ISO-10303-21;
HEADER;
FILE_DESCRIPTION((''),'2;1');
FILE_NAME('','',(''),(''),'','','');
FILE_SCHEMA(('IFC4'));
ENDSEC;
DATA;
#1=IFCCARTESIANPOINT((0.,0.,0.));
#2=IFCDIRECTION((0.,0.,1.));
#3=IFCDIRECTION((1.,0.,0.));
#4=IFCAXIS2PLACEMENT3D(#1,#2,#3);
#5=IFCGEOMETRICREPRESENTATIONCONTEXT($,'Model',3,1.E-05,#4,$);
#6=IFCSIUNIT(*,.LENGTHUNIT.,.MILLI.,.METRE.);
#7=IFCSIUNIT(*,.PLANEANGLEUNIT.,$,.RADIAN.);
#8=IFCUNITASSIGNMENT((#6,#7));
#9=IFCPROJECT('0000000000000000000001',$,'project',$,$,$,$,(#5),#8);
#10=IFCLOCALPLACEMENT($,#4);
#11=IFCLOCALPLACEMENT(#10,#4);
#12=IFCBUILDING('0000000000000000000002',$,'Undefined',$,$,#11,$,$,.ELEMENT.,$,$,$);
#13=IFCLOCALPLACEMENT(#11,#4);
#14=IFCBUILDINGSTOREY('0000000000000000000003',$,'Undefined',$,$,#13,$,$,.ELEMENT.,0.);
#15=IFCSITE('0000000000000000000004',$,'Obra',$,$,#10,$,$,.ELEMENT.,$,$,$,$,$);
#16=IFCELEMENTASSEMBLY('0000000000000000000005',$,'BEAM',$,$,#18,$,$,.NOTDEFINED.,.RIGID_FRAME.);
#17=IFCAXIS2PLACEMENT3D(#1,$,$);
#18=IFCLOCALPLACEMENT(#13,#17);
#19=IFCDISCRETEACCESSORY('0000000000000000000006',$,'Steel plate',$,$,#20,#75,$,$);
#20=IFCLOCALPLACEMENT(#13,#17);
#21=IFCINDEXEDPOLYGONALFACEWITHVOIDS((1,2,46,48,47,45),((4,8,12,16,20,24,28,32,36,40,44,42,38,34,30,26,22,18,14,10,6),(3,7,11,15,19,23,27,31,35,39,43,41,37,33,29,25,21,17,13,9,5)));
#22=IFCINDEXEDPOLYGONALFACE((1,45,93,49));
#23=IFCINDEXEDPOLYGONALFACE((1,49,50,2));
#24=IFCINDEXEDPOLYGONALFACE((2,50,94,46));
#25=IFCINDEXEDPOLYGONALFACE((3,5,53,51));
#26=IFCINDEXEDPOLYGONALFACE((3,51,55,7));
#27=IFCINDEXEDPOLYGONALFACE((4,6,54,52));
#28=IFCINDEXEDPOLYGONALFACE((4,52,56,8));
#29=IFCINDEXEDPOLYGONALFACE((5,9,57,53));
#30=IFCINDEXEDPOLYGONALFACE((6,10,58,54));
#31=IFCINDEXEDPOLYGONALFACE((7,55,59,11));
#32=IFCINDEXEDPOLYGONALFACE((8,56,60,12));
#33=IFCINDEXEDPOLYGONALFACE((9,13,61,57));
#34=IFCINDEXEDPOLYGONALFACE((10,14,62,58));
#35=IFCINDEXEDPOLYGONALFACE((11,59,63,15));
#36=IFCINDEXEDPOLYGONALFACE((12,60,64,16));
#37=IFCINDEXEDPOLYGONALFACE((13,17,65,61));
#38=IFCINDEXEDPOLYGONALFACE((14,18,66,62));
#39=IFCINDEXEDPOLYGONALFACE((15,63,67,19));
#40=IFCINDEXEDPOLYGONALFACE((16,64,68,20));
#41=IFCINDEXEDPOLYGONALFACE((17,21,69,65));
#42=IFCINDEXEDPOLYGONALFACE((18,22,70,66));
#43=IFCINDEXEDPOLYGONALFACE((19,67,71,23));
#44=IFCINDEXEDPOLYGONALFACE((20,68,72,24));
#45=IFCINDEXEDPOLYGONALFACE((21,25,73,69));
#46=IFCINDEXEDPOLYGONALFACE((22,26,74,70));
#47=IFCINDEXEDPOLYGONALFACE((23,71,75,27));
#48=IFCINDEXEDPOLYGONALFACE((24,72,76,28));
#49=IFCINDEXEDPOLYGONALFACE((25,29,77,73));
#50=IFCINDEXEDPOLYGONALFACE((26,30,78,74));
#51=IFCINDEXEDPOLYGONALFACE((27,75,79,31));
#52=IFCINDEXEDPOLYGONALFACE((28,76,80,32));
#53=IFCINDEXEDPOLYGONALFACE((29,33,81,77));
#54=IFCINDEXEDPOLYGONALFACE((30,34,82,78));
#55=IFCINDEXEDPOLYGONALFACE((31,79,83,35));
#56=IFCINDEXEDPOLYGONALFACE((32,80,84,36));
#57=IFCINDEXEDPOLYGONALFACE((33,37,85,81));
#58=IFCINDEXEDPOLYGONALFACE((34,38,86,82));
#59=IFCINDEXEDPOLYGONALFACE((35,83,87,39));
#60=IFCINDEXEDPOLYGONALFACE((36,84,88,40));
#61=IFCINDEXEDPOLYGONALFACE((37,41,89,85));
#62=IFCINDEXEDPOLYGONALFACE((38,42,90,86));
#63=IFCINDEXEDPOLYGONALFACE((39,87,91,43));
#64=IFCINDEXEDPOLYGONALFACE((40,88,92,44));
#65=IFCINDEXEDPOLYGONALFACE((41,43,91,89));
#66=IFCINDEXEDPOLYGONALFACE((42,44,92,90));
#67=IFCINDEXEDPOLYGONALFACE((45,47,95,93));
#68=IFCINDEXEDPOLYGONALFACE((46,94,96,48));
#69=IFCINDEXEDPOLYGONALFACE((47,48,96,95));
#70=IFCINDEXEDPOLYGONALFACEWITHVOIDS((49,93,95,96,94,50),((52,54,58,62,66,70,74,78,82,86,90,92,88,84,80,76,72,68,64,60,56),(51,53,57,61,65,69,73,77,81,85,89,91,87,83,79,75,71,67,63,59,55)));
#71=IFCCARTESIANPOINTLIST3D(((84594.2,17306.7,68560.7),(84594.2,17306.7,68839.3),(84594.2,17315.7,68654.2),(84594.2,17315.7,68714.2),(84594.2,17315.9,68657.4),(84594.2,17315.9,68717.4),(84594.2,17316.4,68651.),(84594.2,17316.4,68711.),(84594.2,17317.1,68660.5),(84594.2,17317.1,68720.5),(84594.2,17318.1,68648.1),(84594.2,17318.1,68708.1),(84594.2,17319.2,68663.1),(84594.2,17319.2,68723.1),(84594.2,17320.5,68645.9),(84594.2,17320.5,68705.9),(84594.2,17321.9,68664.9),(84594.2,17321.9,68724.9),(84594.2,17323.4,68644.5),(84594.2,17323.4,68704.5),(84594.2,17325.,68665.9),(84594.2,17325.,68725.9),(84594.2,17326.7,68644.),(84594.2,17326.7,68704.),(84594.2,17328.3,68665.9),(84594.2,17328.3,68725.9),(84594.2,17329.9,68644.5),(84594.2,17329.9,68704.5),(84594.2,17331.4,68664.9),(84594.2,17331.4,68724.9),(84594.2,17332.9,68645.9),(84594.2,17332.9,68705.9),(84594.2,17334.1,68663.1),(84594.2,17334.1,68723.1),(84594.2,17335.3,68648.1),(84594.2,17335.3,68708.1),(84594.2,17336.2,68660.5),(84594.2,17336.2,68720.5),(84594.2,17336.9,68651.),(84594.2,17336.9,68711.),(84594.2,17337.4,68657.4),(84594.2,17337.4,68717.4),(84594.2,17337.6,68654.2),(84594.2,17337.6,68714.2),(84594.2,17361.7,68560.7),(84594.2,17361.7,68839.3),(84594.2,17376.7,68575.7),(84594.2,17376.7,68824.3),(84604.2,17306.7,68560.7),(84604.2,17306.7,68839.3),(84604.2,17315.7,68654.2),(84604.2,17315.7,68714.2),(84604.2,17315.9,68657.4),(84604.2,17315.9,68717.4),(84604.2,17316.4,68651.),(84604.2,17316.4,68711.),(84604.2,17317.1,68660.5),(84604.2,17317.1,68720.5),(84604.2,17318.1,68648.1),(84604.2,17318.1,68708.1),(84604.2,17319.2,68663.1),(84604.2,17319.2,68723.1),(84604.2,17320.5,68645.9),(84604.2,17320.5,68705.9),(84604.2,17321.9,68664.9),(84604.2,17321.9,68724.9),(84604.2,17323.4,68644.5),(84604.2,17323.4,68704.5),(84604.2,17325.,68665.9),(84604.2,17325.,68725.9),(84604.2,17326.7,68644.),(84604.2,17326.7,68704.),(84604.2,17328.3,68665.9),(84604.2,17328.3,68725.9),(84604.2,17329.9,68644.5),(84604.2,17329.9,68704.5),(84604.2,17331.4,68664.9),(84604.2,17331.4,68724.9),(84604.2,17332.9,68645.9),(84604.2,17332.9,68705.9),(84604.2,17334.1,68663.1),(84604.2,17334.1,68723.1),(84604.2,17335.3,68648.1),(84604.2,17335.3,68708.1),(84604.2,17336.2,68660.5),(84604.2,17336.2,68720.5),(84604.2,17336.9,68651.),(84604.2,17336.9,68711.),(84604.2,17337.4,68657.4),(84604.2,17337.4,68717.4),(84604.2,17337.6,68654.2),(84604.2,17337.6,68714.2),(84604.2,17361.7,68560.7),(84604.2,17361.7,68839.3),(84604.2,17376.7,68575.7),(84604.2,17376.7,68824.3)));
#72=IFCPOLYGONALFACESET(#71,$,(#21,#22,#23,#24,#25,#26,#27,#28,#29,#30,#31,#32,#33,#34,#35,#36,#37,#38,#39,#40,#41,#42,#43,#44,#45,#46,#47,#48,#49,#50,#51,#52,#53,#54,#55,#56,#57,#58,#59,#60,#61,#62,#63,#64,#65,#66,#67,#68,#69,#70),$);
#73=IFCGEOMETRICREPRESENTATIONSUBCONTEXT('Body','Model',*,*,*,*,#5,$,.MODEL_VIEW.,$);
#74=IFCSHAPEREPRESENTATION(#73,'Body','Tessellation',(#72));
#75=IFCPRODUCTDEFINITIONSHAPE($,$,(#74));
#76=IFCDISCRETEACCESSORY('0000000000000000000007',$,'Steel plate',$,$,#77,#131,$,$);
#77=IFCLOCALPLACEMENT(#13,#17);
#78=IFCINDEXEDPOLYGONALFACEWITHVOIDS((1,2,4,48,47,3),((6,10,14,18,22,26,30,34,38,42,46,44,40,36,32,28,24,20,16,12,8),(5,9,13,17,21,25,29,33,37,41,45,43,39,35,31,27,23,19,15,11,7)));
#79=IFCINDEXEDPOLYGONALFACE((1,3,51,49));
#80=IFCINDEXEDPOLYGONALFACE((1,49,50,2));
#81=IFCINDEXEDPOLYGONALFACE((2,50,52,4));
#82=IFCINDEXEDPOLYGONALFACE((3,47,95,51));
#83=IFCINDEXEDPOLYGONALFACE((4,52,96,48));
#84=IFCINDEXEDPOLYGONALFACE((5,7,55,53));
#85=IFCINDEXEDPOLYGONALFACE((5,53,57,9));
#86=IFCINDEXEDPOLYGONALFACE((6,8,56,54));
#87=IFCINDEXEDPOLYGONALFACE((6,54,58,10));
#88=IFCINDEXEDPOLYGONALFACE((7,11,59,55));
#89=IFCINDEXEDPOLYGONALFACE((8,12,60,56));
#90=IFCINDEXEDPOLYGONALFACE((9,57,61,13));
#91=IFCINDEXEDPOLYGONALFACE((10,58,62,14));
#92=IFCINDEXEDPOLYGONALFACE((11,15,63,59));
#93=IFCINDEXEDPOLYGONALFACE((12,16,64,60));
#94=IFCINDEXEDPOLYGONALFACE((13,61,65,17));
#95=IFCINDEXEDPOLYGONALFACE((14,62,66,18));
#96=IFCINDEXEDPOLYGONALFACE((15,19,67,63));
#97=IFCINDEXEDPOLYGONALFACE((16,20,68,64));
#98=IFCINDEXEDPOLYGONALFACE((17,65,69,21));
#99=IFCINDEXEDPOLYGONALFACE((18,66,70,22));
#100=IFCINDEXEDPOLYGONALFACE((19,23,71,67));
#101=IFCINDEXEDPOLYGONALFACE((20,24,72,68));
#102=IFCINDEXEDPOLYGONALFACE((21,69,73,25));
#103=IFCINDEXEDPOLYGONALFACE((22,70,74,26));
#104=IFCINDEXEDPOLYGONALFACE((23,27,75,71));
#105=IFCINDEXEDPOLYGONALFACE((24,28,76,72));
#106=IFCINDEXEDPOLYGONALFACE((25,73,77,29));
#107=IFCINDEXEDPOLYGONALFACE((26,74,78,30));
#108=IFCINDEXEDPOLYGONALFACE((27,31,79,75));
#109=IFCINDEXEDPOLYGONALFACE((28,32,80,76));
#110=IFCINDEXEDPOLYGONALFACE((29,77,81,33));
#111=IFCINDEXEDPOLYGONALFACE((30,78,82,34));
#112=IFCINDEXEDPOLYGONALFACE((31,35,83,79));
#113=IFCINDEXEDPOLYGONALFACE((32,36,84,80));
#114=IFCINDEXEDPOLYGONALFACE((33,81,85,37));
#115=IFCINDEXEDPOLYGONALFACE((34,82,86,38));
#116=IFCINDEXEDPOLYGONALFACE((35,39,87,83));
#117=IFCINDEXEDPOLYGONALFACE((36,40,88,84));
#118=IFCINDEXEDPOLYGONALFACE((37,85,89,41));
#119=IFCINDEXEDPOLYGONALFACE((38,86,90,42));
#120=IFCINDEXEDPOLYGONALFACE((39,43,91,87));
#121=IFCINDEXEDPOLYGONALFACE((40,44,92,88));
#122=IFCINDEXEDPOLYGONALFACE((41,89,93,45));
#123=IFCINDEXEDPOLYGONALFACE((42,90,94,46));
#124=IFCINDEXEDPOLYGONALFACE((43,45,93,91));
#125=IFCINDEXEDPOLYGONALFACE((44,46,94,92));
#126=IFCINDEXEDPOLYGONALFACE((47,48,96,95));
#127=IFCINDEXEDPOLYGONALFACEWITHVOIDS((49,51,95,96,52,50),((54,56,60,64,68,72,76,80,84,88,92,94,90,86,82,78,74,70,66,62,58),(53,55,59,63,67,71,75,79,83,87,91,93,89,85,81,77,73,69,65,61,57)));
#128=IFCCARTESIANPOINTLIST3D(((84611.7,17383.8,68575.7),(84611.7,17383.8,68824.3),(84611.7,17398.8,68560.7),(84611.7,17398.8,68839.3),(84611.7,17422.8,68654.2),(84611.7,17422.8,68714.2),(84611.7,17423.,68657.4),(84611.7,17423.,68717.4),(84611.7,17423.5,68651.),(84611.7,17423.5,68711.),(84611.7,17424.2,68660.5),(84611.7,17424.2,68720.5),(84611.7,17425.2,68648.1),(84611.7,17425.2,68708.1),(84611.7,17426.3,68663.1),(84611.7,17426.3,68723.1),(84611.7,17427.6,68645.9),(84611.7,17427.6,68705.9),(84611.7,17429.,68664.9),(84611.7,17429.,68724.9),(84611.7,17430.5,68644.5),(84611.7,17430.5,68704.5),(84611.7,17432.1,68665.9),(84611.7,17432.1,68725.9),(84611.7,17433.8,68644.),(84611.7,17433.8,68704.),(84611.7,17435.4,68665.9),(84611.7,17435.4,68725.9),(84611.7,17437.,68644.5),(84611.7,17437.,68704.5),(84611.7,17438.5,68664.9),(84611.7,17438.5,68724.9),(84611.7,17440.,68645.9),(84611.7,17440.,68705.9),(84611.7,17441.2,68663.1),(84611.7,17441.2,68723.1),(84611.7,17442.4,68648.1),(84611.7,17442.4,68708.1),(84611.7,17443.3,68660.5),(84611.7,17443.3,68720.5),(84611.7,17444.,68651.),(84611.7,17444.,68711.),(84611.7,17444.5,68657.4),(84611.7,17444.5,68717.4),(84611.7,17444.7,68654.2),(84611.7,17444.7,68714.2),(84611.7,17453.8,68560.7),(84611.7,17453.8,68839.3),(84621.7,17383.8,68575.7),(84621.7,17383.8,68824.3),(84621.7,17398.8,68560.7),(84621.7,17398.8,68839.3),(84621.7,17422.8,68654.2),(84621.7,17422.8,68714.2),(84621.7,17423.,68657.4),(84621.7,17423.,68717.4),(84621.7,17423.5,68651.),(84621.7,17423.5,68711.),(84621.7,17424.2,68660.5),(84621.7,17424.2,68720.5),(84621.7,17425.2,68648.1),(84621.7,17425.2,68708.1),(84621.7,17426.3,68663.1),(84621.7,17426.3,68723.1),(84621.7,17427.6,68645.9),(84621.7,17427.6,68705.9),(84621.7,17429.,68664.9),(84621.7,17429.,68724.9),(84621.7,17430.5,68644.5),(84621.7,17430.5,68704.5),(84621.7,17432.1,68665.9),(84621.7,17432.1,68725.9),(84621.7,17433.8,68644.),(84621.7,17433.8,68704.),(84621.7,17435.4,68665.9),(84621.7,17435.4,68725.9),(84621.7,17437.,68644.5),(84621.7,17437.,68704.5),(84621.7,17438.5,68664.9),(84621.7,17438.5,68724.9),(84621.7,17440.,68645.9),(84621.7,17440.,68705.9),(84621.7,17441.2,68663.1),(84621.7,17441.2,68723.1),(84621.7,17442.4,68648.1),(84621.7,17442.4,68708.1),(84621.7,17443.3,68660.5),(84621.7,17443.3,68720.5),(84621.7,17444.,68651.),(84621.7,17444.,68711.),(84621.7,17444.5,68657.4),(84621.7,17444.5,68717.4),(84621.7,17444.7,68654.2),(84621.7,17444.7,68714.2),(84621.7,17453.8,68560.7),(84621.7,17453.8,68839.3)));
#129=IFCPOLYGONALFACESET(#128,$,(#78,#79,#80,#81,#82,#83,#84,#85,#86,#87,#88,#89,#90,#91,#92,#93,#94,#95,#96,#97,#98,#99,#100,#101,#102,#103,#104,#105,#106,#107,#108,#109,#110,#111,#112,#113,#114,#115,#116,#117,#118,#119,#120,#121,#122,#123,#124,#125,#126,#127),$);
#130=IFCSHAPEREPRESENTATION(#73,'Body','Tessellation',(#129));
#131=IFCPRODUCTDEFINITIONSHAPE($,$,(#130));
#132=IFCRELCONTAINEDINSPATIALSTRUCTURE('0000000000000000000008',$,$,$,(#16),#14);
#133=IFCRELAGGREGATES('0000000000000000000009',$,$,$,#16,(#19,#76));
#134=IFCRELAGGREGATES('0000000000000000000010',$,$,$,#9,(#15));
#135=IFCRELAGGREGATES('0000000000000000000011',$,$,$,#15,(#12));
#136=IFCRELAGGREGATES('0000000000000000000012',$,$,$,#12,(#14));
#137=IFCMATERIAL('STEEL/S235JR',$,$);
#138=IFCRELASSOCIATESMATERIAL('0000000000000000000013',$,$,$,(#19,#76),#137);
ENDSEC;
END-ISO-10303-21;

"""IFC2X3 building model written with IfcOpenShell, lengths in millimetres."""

from ifc_helpers import new_model, si_unit, frame, origin_with_axes, origin_2d_with_axis, place, context, subcontext, project, spatial, polyline, circle, outline, extrude, source, transform, mapped, material, element, aggregate, save


model = new_model("IFC2X3")

# Units and contexts
model_context = context("Model", 3, precision=1e-05, world=origin_with_axes())
body_context = subcontext(model_context, "Body", "Model", "MODEL_VIEW")
ifc_project = project(units=[si_unit("LENGTHUNIT", "METRE", prefix="MILLI"), si_unit("PLANEANGLEUNIT", "RADIAN")], contexts=[model_context])

# Site, building, storey
site_placement = place(None, origin_with_axes())
site = spatial("IfcSite", under=ifc_project, at=site_placement, Name="Obra", CompositionType="ELEMENT")
building_placement = place(site_placement, origin_with_axes())
building = spatial("IfcBuilding", under=site, at=building_placement, Name="Undefined", CompositionType="ELEMENT")
storey_placement = place(building_placement, origin_with_axes())
storey = spatial("IfcBuildingStorey", under=building, at=storey_placement, Name="Undefined", CompositionType="ELEMENT", Elevation=0.0)

# Shared definitions
ifc_material = material(Name="STEEL/S235JR")

# Element assembly
assembly_1_placement = place(storey_placement, origin_with_axes())
assembly_1 = element("IfcElementAssembly", 1, at=assembly_1_placement, inside=storey, Name="BEAM", AssemblyPlace="NOTDEFINED", PredefinedType="RIGID_FRAME")

# Discrete accessories, openings
shared_shape_1 = source(origin_with_axes(), body_context, "Body", "SweptSolid", [
    extrude(circle(Radius=11.0, at=origin_2d_with_axis()), frame((0.0, -13.9, 0.0), z_axis=(0.0, 1.0, 0.0), x_axis=(1.0, 0.0, 0.0)), (0.0, 0.0, 1.0), 10.2),
])
discrete_accessory_1_placement = place(assembly_1_placement, frame((84599.2, 17306.7, 68560.7), z_axis=(1.0, 0.0, 0.0), x_axis=(0.0, 1.0, 0.0)))
discrete_accessory_1 = element("IfcDiscreteAccessory", 2, at=discrete_accessory_1_placement, material=ifc_material, Name="Steel plate", context=body_context, shape_type="SweptSolid", body=[
    extrude(outline(polyline([(0.0, 0.0), (55.0, 0.0), (70.0, 15.0), (70.0, 263.6), (55.0, 278.6), (0.0, 278.6), (0.0, 0.0)])), frame((0.0, 0.0, -5.0), z_axis=(0.0, 0.0, 1.0), x_axis=(1.0, 0.0, 0.0)), (0.0, 0.0, 1.0), 10.0),
])
opening_1_placement = place(assembly_1_placement, frame((84607.9, 17366.7, 68850.0), z_axis=(0.0, -1.0, 0.0), x_axis=(0.0, 0.0, -1.0)))
element("IfcOpeningElement", 3, at=opening_1_placement, cuts=discrete_accessory_1, ObjectType="Opening", context=body_context, shape_type="MappedRepresentation", body=[
    mapped(shared_shape_1, transform((135.0, 0.0, 40.0))),
    mapped(shared_shape_1, transform((195.0, 0.0, 40.0))),
])
discrete_accessory_2_placement = place(assembly_1_placement, frame((84616.7, 17453.8, 68560.7), z_axis=(-1.0, 0.0, 0.0), x_axis=(0.0, -1.0, 0.0)))
discrete_accessory_2 = element("IfcDiscreteAccessory", 4, at=discrete_accessory_2_placement, material=ifc_material, Name="Steel plate", context=body_context, shape_type="SweptSolid", body=[
    extrude(outline(polyline([(0.0, 0.0), (55.0, 0.0), (70.0, 15.0), (70.0, 263.6), (55.0, 278.6), (0.0, 278.6), (0.0, 0.0)])), frame((0.0, 0.0, -5.0), z_axis=(0.0, 0.0, 1.0), x_axis=(1.0, 0.0, 0.0)), (0.0, 0.0, 1.0), 10.0),
])
opening_2_placement = place(assembly_1_placement, frame((84607.9, 17393.8, 68850.0), z_axis=(0.0, 1.0, 0.0), x_axis=(0.0, 0.0, -1.0)))
element("IfcOpeningElement", 5, at=opening_2_placement, cuts=discrete_accessory_2, ObjectType="Opening", context=body_context, shape_type="MappedRepresentation", body=[
    mapped(shared_shape_1, transform((135.0, 0.0, 40.0))),
    mapped(shared_shape_1, transform((195.0, 0.0, 40.0))),
])
aggregate(assembly_1, [discrete_accessory_1, discrete_accessory_2])

save(model, "model.ifc")
